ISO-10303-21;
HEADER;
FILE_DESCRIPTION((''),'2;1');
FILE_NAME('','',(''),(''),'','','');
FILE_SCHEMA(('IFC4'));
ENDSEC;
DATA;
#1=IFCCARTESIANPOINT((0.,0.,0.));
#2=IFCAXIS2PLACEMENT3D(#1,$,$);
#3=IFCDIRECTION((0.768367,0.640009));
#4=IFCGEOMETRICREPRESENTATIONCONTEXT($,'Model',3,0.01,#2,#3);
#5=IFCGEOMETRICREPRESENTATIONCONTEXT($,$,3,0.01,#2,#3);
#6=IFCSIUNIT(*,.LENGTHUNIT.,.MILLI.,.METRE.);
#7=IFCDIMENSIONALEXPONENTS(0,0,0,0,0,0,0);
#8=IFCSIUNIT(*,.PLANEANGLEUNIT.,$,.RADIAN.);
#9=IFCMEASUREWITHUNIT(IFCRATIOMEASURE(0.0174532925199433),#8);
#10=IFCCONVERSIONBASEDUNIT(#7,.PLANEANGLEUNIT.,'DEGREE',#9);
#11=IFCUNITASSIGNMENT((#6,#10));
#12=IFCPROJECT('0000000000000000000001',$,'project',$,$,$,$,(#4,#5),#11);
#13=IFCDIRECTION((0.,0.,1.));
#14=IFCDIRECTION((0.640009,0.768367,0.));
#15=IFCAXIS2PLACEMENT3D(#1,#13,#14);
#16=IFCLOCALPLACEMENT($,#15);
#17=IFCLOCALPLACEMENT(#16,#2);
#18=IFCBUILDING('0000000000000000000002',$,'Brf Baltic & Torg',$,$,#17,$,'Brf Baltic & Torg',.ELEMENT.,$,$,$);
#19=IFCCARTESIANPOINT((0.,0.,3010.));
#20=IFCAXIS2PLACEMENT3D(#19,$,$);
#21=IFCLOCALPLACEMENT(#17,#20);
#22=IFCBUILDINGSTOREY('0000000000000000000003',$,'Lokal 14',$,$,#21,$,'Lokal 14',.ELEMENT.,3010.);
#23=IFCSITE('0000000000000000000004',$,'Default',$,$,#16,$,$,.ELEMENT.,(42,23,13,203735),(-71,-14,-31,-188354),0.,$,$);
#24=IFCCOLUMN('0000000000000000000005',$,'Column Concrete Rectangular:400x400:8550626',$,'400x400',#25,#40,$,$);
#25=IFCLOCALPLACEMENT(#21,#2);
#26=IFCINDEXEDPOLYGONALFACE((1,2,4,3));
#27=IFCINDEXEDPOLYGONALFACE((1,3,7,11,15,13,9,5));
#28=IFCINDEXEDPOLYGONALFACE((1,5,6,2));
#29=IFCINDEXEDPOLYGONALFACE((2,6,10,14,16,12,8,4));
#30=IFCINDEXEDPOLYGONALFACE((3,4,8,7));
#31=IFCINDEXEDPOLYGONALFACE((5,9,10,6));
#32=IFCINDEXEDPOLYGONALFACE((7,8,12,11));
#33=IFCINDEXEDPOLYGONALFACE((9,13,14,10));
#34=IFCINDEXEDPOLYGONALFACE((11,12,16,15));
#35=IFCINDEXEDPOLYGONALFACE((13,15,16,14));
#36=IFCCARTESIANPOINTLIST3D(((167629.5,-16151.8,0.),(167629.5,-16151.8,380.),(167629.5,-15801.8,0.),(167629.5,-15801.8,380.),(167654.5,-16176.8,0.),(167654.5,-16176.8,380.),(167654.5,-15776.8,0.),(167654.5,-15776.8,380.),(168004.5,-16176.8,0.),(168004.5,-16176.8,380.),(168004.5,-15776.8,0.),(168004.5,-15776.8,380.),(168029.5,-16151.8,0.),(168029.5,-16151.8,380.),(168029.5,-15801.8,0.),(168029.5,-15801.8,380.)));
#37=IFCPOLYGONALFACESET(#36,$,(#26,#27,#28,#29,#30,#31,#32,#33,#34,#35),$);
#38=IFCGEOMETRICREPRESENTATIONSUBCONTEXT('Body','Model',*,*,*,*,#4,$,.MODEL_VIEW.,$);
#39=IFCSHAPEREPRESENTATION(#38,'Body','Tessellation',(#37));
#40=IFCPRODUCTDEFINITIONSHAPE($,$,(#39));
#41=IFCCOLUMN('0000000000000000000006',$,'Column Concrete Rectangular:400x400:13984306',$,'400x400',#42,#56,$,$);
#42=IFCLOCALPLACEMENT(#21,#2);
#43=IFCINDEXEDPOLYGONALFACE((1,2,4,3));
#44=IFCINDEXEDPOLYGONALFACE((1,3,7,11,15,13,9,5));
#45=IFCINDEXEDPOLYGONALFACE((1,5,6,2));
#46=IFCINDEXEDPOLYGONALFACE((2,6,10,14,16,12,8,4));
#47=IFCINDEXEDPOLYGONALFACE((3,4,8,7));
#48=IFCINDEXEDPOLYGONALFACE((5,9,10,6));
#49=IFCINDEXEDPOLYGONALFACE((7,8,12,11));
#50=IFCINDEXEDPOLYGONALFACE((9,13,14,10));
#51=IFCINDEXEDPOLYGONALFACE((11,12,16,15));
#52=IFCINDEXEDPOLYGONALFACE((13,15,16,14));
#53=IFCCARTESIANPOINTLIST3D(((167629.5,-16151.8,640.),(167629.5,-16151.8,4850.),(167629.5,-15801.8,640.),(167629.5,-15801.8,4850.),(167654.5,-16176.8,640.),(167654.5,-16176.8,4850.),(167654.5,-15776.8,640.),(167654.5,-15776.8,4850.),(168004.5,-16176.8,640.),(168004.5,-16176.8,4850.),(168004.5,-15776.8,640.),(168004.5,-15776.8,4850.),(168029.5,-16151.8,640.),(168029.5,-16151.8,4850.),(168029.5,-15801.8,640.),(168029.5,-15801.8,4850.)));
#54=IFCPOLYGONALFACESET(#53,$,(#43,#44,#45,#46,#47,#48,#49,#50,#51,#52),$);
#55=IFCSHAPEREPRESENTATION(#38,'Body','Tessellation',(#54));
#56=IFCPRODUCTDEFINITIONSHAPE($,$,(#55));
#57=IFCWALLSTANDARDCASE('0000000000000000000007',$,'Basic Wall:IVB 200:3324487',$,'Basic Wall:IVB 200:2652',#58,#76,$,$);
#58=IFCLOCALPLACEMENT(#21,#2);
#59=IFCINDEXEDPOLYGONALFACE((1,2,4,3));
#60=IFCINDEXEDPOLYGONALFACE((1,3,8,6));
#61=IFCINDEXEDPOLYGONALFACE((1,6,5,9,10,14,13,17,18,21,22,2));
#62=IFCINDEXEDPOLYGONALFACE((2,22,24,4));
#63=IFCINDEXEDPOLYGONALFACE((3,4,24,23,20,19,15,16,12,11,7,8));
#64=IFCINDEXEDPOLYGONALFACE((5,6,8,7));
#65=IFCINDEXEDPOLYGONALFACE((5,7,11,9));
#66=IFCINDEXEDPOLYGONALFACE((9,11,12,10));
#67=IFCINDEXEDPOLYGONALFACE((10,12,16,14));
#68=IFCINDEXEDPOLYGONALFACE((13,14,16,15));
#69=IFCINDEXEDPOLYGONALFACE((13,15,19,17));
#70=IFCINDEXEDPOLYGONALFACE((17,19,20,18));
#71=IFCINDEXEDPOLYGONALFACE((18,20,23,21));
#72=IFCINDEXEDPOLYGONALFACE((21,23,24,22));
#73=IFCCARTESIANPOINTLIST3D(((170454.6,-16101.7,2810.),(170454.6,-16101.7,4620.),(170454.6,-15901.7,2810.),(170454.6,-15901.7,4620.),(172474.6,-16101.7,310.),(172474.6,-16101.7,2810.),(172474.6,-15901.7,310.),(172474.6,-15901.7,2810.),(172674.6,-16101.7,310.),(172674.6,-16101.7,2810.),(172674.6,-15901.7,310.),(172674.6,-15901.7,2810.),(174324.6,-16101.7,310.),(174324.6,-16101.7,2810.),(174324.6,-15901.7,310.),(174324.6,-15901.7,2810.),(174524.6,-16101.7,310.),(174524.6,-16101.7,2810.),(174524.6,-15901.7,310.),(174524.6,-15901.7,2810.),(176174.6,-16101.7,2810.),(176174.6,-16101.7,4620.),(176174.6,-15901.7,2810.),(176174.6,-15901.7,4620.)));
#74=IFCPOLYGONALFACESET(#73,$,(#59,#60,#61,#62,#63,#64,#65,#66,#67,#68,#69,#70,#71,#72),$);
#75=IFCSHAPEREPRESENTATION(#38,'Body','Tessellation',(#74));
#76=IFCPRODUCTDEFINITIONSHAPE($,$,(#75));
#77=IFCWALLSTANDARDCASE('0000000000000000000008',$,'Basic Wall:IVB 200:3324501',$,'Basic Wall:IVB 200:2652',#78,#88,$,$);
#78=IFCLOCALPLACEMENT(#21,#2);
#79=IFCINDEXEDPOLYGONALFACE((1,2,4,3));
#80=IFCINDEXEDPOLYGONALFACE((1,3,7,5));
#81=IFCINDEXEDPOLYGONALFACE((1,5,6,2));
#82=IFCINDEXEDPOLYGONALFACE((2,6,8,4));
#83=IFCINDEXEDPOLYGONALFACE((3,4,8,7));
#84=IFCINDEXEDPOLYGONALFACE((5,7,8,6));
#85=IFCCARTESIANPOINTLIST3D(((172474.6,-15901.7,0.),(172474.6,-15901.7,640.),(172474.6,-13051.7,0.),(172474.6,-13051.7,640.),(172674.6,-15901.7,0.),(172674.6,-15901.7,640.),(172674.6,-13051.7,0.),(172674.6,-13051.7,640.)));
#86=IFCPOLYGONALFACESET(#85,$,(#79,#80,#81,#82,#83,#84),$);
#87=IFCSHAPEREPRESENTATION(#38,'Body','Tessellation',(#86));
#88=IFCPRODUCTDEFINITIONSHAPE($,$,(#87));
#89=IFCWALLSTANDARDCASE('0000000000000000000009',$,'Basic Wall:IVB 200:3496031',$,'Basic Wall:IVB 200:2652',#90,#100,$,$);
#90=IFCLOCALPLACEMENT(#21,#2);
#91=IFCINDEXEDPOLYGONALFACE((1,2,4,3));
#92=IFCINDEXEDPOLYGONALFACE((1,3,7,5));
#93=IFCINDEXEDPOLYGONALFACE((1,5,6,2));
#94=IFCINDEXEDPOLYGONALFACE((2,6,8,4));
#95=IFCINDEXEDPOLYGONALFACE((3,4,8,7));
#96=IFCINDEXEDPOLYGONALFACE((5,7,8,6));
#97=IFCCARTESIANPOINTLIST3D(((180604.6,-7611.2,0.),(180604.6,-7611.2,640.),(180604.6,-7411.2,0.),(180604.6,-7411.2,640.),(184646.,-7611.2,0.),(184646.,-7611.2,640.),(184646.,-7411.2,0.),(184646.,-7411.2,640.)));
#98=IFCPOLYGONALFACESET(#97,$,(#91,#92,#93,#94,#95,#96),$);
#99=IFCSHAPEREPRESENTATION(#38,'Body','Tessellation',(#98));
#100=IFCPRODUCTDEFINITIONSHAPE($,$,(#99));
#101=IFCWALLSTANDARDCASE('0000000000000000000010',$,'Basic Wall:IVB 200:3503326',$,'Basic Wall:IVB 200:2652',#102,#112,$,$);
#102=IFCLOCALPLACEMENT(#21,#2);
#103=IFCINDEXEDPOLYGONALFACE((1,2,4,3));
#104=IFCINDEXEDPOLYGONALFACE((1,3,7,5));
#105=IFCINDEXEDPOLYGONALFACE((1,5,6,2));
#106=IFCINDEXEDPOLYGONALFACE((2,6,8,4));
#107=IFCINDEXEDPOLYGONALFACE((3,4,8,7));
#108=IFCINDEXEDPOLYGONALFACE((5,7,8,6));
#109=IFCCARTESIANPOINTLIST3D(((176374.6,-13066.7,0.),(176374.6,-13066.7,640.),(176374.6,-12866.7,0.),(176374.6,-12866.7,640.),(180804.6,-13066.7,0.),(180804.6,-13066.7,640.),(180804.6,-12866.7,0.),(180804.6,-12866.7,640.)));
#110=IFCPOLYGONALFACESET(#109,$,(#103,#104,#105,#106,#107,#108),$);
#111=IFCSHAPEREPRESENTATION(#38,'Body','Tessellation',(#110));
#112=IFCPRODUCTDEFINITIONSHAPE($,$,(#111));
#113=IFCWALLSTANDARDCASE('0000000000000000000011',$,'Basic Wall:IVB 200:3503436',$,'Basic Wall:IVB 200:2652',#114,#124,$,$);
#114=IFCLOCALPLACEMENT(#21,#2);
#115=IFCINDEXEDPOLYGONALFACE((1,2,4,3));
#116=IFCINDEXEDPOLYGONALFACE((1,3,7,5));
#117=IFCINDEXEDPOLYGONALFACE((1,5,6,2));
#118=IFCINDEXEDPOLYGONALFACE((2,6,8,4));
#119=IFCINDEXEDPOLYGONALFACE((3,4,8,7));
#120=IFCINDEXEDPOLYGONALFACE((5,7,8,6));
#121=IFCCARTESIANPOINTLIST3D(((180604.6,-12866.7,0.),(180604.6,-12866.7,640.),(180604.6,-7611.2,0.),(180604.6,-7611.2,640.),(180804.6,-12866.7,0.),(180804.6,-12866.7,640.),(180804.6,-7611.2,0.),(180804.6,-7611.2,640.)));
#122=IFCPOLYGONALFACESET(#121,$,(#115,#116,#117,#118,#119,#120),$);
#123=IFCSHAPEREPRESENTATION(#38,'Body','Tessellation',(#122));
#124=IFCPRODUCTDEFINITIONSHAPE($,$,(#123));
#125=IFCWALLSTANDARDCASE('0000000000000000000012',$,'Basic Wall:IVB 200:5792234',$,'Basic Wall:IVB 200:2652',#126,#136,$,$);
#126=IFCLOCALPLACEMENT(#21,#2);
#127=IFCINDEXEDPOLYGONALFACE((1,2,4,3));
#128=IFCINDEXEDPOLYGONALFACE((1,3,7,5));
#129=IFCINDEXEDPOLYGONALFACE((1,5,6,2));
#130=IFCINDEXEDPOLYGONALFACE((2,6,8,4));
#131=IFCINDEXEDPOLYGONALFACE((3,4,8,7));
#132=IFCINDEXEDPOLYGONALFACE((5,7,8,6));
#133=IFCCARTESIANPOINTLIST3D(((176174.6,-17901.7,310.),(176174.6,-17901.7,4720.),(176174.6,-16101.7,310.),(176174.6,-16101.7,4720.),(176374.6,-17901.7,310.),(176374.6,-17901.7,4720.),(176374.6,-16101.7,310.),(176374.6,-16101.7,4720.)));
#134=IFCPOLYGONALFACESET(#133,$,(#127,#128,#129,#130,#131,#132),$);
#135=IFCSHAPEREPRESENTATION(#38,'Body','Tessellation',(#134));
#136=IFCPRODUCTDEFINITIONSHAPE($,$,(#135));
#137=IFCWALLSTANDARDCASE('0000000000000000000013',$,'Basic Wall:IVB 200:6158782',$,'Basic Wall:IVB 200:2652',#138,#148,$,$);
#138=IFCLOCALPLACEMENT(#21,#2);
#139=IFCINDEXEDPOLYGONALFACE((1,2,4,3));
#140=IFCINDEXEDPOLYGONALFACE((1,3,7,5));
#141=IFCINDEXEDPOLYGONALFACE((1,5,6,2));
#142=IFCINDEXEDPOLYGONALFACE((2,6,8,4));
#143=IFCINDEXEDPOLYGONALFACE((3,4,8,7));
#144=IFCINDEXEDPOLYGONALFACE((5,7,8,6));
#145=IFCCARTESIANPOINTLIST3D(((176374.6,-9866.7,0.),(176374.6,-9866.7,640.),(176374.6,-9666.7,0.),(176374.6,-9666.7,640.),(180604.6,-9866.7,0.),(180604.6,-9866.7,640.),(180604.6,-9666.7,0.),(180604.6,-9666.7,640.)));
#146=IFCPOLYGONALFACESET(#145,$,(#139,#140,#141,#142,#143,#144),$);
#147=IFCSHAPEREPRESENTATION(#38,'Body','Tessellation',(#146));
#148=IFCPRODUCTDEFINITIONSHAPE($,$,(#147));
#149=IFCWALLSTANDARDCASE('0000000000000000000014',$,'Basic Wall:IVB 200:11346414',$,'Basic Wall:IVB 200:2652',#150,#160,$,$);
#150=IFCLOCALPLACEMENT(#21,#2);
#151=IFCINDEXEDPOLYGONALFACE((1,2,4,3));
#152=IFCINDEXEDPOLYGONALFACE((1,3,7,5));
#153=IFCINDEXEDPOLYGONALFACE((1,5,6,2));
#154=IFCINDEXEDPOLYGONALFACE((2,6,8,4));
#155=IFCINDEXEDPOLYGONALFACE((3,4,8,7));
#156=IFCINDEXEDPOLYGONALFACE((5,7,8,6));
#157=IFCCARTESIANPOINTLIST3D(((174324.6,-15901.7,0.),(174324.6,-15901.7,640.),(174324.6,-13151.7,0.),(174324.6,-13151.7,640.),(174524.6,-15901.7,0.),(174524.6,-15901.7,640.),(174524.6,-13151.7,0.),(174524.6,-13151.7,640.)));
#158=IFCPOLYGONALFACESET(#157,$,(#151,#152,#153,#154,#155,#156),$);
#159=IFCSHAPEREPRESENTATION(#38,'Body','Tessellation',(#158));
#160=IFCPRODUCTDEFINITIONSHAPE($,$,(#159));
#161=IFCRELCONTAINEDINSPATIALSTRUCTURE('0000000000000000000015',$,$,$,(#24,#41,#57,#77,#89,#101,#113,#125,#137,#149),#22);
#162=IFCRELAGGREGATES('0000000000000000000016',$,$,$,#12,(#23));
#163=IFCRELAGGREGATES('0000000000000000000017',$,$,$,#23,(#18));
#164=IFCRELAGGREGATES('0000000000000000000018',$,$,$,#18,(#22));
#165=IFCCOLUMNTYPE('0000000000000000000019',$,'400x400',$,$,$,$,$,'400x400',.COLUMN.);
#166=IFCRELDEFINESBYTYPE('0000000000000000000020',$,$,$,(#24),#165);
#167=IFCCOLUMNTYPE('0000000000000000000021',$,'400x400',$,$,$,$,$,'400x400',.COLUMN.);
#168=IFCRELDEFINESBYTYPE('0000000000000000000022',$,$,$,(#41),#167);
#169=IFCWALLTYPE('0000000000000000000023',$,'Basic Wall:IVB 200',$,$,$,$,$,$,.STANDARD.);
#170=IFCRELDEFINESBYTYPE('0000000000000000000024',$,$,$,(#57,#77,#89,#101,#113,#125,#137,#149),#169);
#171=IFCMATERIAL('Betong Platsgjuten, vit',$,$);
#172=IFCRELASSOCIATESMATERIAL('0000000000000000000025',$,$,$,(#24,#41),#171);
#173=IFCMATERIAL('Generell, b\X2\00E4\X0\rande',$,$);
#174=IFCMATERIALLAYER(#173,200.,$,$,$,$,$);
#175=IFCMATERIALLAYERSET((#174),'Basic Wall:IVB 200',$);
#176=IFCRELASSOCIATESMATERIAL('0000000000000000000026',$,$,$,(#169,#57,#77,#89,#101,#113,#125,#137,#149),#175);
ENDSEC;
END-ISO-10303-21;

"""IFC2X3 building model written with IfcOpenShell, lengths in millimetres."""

from ifc_helpers import new_model, entity, si_unit, converted_unit, direction, frame, frame_2d, origin, place, context, subcontext, project, spatial, polyline, rectangle, outline, extrude, clip, halfspace, source, transform, mapped, material, layer, layer_set, layer_usage, type_object, type_shapes, element, save


model = new_model("IFC2X3")

# Units and contexts
model_context = context("Model", 3, precision=0.01, world=origin(), true_north=direction((0.768367, 0.640009)))
context_of_model = context(None, 3, precision=0.01, world=origin(), true_north=direction((0.768367, 0.640009)))
body_context = subcontext(model_context, "Body", "Model", "MODEL_VIEW")
ifc_project = project(units=[si_unit("LENGTHUNIT", "METRE", prefix="MILLI"), converted_unit("PLANEANGLEUNIT", "DEGREE", entity("IfcRatioMeasure", 0.0174532925199433), si_unit("PLANEANGLEUNIT", "RADIAN"), dimensions=[0, 0, 0, 0, 0, 0, 0])], contexts=[model_context, context_of_model])

# Site, building, storey
site_placement = place(None, frame((0.0, 0.0, 0.0), z_axis=(0.0, 0.0, 1.0), x_axis=(0.640009, 0.768367, 0.0)))
site = spatial("IfcSite", under=ifc_project, at=site_placement, Name="Default", CompositionType="ELEMENT", RefLatitude=(42, 23, 13, 203735), RefLongitude=(-71, -14, -31, -188354), RefElevation=0.0)
building_placement = place(site_placement, origin())
building = spatial("IfcBuilding", under=site, at=building_placement, Name="Brf Baltic & Torg", LongName="Brf Baltic & Torg", CompositionType="ELEMENT")
storey_placement = place(building_placement, frame((0.0, 0.0, 3010.0)))
storey = spatial("IfcBuildingStorey", under=building, at=storey_placement, Name="Lokal 14", LongName="Lokal 14", CompositionType="ELEMENT", Elevation=3010.0)

# Columns
ifc_material_1 = material(Name="Betong Platsgjuten, vit")
column_type_1 = type_object("IfcColumnType", Name="400x400", ElementType="400x400", PredefinedType="COLUMN")
shared_shape_1 = source(origin(), body_context, "Body", "SweptSolid", [
    extrude(outline(polyline([(-175.0, -200.0), (175.0, -200.0), (200.0, -175.0), (200.0, 175.0), (175.0, 200.0), (-175.0, 200.0), (-200.0, 175.0), (-200.0, -175.0), (-175.0, -200.0)])), frame((0.0, 0.0, 3010.0), z_axis=(0.0, 0.0, 1.0), x_axis=(0.0, -1.0, 0.0)), (0.0, 0.0, 1.0), 380.0),
])
type_shapes(column_type_1, [shared_shape_1])
column_1_placement = place(storey_placement, frame((167829.5, -15976.8, -3010.0)))
element("IfcColumn", 1, at=column_1_placement, inside=storey, type_object=column_type_1, material=ifc_material_1, Name="Column Concrete Rectangular:400x400:8550626", ObjectType="400x400", context=body_context, shape_type="MappedRepresentation", body=[
    mapped(shared_shape_1, transform((0.0, 0.0, 0.0), scale=1.0)),
])
column_type_2 = type_object("IfcColumnType", Name="400x400", ElementType="400x400", PredefinedType="COLUMN")
shared_shape_2 = source(origin(), body_context, "Body", "SweptSolid", [
    extrude(outline(polyline([(-175.0, -200.0), (175.0, -200.0), (200.0, -175.0), (200.0, 175.0), (175.0, 200.0), (-175.0, 200.0), (-200.0, 175.0), (-200.0, -175.0), (-175.0, -200.0)])), frame((0.0, 0.0, 3650.0), z_axis=(0.0, 0.0, 1.0), x_axis=(0.0, -1.0, 0.0)), (0.0, 0.0, 1.0), 4210.0),
])
type_shapes(column_type_2, [shared_shape_2])
column_2_placement = place(storey_placement, frame((167829.5, -15976.8, -3010.0)))
element("IfcColumn", 2, at=column_2_placement, inside=storey, type_object=column_type_2, material=ifc_material_1, Name="Column Concrete Rectangular:400x400:13984306", ObjectType="400x400", context=body_context, shape_type="MappedRepresentation", body=[
    mapped(shared_shape_2, transform((0.0, 0.0, 0.0), scale=1.0)),
])

# Shared definitions
ifc_material_2 = material(Name="Generell, bärande")
ifc_layer_1 = layer(ifc_material_2, 200.0)
ifc_layer_set_1 = layer_set([ifc_layer_1], Name="Basic Wall:IVB 200")
wall_type_1 = type_object("IfcWallType", Name="Basic Wall:IVB 200", PredefinedType="STANDARD", material=ifc_layer_set_1)

# Wall, openings
ifc_layer_usage_1 = layer_usage(ifc_layer_set_1, "AXIS2", "NEGATIVE", 100.0)
wall_1_placement = place(storey_placement, frame((176174.6, -16001.7, 310.0), z_axis=(0.0, 0.0, 1.0), x_axis=(-1.0, 0.0, 0.0)))
wall_1 = element("IfcWallStandardCase", 3, at=wall_1_placement, inside=storey, type_object=wall_type_1, material=ifc_layer_usage_1, Name="Basic Wall:IVB 200:3324487", ObjectType="Basic Wall:IVB 200:2652", context=body_context, shape_type="SweptSolid", body=[
    extrude(rectangle(XDim=5720.0, YDim=200.0, at=frame_2d((2860.0, 0.0), x_axis=(-1.0, 0.0))), origin(), (0.0, 0.0, 1.0), 4310.0),
])
opening_1_placement = place(wall_1_placement, frame((176174.6, -16001.7, -310.0), z_axis=(0.0, 0.0, 1.0), x_axis=(-1.0, 0.0, 0.0)))
element("IfcOpeningElement", 4, at=opening_1_placement, cuts=wall_1, ObjectType="Opening", context=body_context, shape_type="SweptSolid", body=[
    extrude(rectangle(XDim=2500.0, YDim=2020.0, at=frame_2d((0.0, 0.0), x_axis=(0.0, 1.0))), frame((171464.6, -14377.7, 1560.0), z_axis=(0.0, -1.0, 0.0), x_axis=(1.0, 0.0, 0.0)), (0.0, 0.0, 1.0), 3048.0),
])
opening_2_placement = place(wall_1_placement, frame((176174.6, -16001.7, -310.0), z_axis=(0.0, 0.0, 1.0), x_axis=(-1.0, 0.0, 0.0)))
element("IfcOpeningElement", 5, at=opening_2_placement, cuts=wall_1, ObjectType="Opening", context=body_context, shape_type="SweptSolid", body=[
    extrude(rectangle(XDim=2500.0, YDim=1650.0, at=frame_2d((0.0, 0.0), x_axis=(0.0, 1.0))), frame((173499.6, -14377.7, 1560.0), z_axis=(0.0, -1.0, 0.0), x_axis=(1.0, 0.0, 0.0)), (0.0, 0.0, 1.0), 3048.0),
])
opening_3_placement = place(wall_1_placement, frame((176174.6, -16001.7, -310.0), z_axis=(0.0, 0.0, 1.0), x_axis=(-1.0, 0.0, 0.0)))
element("IfcOpeningElement", 6, at=opening_3_placement, cuts=wall_1, ObjectType="Opening", context=body_context, shape_type="SweptSolid", body=[
    extrude(rectangle(XDim=2500.0, YDim=1650.0, at=frame_2d((0.0, 0.0), x_axis=(0.0, 1.0))), frame((175349.6, -14377.7, 1560.0), z_axis=(0.0, -1.0, 0.0), x_axis=(1.0, 0.0, 0.0)), (0.0, 0.0, 1.0), 3048.0),
])

# Wall
ifc_layer_usage_2 = layer_usage(ifc_layer_set_1, "AXIS2", "POSITIVE", -100.0)
wall_2_placement = place(storey_placement, frame((172574.6, -15901.7, 0.0), z_axis=(0.0, 0.0, 1.0), x_axis=(0.0, 1.0, 0.0)))
element("IfcWallStandardCase", 7, at=wall_2_placement, inside=storey, type_object=wall_type_1, material=ifc_layer_usage_2, Name="Basic Wall:IVB 200:3324501", ObjectType="Basic Wall:IVB 200:2652", context=body_context, shape_type="Clipping", body=[
    clip(extrude(rectangle(XDim=2850.0, YDim=200.0, at=frame_2d((1425.0, 0.0), x_axis=(-1.0, 0.0))), origin(), (0.0, 0.0, 1.0), 640.0), halfspace(frame((0.0, 0.0, -1360.0)), True)),
])

# Walls
ifc_layer_usage_3 = layer_usage(ifc_layer_set_1, "AXIS2", "NEGATIVE", 100.0)
wall_3_placement = place(storey_placement, frame((180604.6, -7511.2, 0.0)))
element("IfcWallStandardCase", 8, at=wall_3_placement, inside=storey, type_object=wall_type_1, material=ifc_layer_usage_3, Name="Basic Wall:IVB 200:3496031", ObjectType="Basic Wall:IVB 200:2652", context=body_context, shape_type="Clipping", body=[
    clip(extrude(rectangle(XDim=4041.4, YDim=200.0, at=frame_2d((2020.7, 0.0), x_axis=(-1.0, 0.0))), origin(), (0.0, 0.0, 1.0), 640.0), halfspace(frame((0.0, 0.0, -1360.0)), True)),
])
ifc_layer_usage_4 = layer_usage(ifc_layer_set_1, "AXIS2", "NEGATIVE", 100.0)
wall_4_placement = place(storey_placement, frame((180804.6, -12966.7, 0.0), z_axis=(0.0, 0.0, 1.0), x_axis=(-1.0, 0.0, 0.0)))
element("IfcWallStandardCase", 9, at=wall_4_placement, inside=storey, type_object=wall_type_1, material=ifc_layer_usage_4, Name="Basic Wall:IVB 200:3503326", ObjectType="Basic Wall:IVB 200:2652", context=body_context, shape_type="Clipping", body=[
    clip(extrude(rectangle(XDim=4430.0, YDim=200.0, at=frame_2d((2215.0, 0.0), x_axis=(-1.0, 0.0))), origin(), (0.0, 0.0, 1.0), 640.0), halfspace(frame((0.0, 0.0, -1360.0)), True)),
])
ifc_layer_usage_5 = layer_usage(ifc_layer_set_1, "AXIS2", "NEGATIVE", 100.0)
wall_5_placement = place(storey_placement, frame((180704.6, -7611.2, 0.0), z_axis=(0.0, 0.0, 1.0), x_axis=(0.0, -1.0, 0.0)))
element("IfcWallStandardCase", 10, at=wall_5_placement, inside=storey, type_object=wall_type_1, material=ifc_layer_usage_5, Name="Basic Wall:IVB 200:3503436", ObjectType="Basic Wall:IVB 200:2652", context=body_context, shape_type="Clipping", body=[
    clip(extrude(rectangle(XDim=5255.5, YDim=200.0, at=frame_2d((2627.7, 0.0), x_axis=(-1.0, 0.0))), origin(), (0.0, 0.0, 1.0), 640.0), halfspace(frame((0.0, 0.0, -1360.0)), True)),
])

# Walls
ifc_layer_usage_6 = layer_usage(ifc_layer_set_1, "AXIS2", "NEGATIVE", 100.0)
wall_6_placement = place(storey_placement, frame((176274.6, -16101.7, 310.0), z_axis=(0.0, 0.0, 1.0), x_axis=(0.0, -1.0, 0.0)))
element("IfcWallStandardCase", 11, at=wall_6_placement, inside=storey, type_object=wall_type_1, material=ifc_layer_usage_6, Name="Basic Wall:IVB 200:5792234", ObjectType="Basic Wall:IVB 200:2652", context=body_context, shape_type="SweptSolid", body=[
    extrude(rectangle(XDim=1800.0, YDim=200.0, at=frame_2d((900.0, 0.0), x_axis=(-1.0, 0.0))), origin(), (0.0, 0.0, 1.0), 4410.0),
])
ifc_layer_usage_7 = layer_usage(ifc_layer_set_1, "AXIS2", "NEGATIVE", 100.0)
wall_7_placement = place(storey_placement, frame((180604.6, -9766.7, 0.0), z_axis=(0.0, 0.0, 1.0), x_axis=(-1.0, 0.0, 0.0)))
element("IfcWallStandardCase", 12, at=wall_7_placement, inside=storey, type_object=wall_type_1, material=ifc_layer_usage_7, Name="Basic Wall:IVB 200:6158782", ObjectType="Basic Wall:IVB 200:2652", context=body_context, shape_type="Clipping", body=[
    clip(extrude(rectangle(XDim=4230.0, YDim=200.0, at=frame_2d((2115.0, 0.0), x_axis=(-1.0, 0.0))), origin(), (0.0, 0.0, 1.0), 640.0), halfspace(frame((0.0, 0.0, -1360.0)), True)),
])

# Wall
ifc_layer_usage_8 = layer_usage(ifc_layer_set_1, "AXIS2", "POSITIVE", -100.0)
wall_8_placement = place(storey_placement, frame((174424.6, -15901.7, 0.0), z_axis=(0.0, 0.0, 1.0), x_axis=(0.0, 1.0, 0.0)))
element("IfcWallStandardCase", 13, at=wall_8_placement, inside=storey, type_object=wall_type_1, material=ifc_layer_usage_8, Name="Basic Wall:IVB 200:11346414", ObjectType="Basic Wall:IVB 200:2652", context=body_context, shape_type="Clipping", body=[
    clip(extrude(rectangle(XDim=2750.0, YDim=200.0, at=frame_2d((1375.0, 0.0), x_axis=(-1.0, 0.0))), origin(), (0.0, 0.0, 1.0), 640.0), halfspace(frame((0.0, 0.0, -1360.0)), True)),
])

save(model, "model.ifc")
